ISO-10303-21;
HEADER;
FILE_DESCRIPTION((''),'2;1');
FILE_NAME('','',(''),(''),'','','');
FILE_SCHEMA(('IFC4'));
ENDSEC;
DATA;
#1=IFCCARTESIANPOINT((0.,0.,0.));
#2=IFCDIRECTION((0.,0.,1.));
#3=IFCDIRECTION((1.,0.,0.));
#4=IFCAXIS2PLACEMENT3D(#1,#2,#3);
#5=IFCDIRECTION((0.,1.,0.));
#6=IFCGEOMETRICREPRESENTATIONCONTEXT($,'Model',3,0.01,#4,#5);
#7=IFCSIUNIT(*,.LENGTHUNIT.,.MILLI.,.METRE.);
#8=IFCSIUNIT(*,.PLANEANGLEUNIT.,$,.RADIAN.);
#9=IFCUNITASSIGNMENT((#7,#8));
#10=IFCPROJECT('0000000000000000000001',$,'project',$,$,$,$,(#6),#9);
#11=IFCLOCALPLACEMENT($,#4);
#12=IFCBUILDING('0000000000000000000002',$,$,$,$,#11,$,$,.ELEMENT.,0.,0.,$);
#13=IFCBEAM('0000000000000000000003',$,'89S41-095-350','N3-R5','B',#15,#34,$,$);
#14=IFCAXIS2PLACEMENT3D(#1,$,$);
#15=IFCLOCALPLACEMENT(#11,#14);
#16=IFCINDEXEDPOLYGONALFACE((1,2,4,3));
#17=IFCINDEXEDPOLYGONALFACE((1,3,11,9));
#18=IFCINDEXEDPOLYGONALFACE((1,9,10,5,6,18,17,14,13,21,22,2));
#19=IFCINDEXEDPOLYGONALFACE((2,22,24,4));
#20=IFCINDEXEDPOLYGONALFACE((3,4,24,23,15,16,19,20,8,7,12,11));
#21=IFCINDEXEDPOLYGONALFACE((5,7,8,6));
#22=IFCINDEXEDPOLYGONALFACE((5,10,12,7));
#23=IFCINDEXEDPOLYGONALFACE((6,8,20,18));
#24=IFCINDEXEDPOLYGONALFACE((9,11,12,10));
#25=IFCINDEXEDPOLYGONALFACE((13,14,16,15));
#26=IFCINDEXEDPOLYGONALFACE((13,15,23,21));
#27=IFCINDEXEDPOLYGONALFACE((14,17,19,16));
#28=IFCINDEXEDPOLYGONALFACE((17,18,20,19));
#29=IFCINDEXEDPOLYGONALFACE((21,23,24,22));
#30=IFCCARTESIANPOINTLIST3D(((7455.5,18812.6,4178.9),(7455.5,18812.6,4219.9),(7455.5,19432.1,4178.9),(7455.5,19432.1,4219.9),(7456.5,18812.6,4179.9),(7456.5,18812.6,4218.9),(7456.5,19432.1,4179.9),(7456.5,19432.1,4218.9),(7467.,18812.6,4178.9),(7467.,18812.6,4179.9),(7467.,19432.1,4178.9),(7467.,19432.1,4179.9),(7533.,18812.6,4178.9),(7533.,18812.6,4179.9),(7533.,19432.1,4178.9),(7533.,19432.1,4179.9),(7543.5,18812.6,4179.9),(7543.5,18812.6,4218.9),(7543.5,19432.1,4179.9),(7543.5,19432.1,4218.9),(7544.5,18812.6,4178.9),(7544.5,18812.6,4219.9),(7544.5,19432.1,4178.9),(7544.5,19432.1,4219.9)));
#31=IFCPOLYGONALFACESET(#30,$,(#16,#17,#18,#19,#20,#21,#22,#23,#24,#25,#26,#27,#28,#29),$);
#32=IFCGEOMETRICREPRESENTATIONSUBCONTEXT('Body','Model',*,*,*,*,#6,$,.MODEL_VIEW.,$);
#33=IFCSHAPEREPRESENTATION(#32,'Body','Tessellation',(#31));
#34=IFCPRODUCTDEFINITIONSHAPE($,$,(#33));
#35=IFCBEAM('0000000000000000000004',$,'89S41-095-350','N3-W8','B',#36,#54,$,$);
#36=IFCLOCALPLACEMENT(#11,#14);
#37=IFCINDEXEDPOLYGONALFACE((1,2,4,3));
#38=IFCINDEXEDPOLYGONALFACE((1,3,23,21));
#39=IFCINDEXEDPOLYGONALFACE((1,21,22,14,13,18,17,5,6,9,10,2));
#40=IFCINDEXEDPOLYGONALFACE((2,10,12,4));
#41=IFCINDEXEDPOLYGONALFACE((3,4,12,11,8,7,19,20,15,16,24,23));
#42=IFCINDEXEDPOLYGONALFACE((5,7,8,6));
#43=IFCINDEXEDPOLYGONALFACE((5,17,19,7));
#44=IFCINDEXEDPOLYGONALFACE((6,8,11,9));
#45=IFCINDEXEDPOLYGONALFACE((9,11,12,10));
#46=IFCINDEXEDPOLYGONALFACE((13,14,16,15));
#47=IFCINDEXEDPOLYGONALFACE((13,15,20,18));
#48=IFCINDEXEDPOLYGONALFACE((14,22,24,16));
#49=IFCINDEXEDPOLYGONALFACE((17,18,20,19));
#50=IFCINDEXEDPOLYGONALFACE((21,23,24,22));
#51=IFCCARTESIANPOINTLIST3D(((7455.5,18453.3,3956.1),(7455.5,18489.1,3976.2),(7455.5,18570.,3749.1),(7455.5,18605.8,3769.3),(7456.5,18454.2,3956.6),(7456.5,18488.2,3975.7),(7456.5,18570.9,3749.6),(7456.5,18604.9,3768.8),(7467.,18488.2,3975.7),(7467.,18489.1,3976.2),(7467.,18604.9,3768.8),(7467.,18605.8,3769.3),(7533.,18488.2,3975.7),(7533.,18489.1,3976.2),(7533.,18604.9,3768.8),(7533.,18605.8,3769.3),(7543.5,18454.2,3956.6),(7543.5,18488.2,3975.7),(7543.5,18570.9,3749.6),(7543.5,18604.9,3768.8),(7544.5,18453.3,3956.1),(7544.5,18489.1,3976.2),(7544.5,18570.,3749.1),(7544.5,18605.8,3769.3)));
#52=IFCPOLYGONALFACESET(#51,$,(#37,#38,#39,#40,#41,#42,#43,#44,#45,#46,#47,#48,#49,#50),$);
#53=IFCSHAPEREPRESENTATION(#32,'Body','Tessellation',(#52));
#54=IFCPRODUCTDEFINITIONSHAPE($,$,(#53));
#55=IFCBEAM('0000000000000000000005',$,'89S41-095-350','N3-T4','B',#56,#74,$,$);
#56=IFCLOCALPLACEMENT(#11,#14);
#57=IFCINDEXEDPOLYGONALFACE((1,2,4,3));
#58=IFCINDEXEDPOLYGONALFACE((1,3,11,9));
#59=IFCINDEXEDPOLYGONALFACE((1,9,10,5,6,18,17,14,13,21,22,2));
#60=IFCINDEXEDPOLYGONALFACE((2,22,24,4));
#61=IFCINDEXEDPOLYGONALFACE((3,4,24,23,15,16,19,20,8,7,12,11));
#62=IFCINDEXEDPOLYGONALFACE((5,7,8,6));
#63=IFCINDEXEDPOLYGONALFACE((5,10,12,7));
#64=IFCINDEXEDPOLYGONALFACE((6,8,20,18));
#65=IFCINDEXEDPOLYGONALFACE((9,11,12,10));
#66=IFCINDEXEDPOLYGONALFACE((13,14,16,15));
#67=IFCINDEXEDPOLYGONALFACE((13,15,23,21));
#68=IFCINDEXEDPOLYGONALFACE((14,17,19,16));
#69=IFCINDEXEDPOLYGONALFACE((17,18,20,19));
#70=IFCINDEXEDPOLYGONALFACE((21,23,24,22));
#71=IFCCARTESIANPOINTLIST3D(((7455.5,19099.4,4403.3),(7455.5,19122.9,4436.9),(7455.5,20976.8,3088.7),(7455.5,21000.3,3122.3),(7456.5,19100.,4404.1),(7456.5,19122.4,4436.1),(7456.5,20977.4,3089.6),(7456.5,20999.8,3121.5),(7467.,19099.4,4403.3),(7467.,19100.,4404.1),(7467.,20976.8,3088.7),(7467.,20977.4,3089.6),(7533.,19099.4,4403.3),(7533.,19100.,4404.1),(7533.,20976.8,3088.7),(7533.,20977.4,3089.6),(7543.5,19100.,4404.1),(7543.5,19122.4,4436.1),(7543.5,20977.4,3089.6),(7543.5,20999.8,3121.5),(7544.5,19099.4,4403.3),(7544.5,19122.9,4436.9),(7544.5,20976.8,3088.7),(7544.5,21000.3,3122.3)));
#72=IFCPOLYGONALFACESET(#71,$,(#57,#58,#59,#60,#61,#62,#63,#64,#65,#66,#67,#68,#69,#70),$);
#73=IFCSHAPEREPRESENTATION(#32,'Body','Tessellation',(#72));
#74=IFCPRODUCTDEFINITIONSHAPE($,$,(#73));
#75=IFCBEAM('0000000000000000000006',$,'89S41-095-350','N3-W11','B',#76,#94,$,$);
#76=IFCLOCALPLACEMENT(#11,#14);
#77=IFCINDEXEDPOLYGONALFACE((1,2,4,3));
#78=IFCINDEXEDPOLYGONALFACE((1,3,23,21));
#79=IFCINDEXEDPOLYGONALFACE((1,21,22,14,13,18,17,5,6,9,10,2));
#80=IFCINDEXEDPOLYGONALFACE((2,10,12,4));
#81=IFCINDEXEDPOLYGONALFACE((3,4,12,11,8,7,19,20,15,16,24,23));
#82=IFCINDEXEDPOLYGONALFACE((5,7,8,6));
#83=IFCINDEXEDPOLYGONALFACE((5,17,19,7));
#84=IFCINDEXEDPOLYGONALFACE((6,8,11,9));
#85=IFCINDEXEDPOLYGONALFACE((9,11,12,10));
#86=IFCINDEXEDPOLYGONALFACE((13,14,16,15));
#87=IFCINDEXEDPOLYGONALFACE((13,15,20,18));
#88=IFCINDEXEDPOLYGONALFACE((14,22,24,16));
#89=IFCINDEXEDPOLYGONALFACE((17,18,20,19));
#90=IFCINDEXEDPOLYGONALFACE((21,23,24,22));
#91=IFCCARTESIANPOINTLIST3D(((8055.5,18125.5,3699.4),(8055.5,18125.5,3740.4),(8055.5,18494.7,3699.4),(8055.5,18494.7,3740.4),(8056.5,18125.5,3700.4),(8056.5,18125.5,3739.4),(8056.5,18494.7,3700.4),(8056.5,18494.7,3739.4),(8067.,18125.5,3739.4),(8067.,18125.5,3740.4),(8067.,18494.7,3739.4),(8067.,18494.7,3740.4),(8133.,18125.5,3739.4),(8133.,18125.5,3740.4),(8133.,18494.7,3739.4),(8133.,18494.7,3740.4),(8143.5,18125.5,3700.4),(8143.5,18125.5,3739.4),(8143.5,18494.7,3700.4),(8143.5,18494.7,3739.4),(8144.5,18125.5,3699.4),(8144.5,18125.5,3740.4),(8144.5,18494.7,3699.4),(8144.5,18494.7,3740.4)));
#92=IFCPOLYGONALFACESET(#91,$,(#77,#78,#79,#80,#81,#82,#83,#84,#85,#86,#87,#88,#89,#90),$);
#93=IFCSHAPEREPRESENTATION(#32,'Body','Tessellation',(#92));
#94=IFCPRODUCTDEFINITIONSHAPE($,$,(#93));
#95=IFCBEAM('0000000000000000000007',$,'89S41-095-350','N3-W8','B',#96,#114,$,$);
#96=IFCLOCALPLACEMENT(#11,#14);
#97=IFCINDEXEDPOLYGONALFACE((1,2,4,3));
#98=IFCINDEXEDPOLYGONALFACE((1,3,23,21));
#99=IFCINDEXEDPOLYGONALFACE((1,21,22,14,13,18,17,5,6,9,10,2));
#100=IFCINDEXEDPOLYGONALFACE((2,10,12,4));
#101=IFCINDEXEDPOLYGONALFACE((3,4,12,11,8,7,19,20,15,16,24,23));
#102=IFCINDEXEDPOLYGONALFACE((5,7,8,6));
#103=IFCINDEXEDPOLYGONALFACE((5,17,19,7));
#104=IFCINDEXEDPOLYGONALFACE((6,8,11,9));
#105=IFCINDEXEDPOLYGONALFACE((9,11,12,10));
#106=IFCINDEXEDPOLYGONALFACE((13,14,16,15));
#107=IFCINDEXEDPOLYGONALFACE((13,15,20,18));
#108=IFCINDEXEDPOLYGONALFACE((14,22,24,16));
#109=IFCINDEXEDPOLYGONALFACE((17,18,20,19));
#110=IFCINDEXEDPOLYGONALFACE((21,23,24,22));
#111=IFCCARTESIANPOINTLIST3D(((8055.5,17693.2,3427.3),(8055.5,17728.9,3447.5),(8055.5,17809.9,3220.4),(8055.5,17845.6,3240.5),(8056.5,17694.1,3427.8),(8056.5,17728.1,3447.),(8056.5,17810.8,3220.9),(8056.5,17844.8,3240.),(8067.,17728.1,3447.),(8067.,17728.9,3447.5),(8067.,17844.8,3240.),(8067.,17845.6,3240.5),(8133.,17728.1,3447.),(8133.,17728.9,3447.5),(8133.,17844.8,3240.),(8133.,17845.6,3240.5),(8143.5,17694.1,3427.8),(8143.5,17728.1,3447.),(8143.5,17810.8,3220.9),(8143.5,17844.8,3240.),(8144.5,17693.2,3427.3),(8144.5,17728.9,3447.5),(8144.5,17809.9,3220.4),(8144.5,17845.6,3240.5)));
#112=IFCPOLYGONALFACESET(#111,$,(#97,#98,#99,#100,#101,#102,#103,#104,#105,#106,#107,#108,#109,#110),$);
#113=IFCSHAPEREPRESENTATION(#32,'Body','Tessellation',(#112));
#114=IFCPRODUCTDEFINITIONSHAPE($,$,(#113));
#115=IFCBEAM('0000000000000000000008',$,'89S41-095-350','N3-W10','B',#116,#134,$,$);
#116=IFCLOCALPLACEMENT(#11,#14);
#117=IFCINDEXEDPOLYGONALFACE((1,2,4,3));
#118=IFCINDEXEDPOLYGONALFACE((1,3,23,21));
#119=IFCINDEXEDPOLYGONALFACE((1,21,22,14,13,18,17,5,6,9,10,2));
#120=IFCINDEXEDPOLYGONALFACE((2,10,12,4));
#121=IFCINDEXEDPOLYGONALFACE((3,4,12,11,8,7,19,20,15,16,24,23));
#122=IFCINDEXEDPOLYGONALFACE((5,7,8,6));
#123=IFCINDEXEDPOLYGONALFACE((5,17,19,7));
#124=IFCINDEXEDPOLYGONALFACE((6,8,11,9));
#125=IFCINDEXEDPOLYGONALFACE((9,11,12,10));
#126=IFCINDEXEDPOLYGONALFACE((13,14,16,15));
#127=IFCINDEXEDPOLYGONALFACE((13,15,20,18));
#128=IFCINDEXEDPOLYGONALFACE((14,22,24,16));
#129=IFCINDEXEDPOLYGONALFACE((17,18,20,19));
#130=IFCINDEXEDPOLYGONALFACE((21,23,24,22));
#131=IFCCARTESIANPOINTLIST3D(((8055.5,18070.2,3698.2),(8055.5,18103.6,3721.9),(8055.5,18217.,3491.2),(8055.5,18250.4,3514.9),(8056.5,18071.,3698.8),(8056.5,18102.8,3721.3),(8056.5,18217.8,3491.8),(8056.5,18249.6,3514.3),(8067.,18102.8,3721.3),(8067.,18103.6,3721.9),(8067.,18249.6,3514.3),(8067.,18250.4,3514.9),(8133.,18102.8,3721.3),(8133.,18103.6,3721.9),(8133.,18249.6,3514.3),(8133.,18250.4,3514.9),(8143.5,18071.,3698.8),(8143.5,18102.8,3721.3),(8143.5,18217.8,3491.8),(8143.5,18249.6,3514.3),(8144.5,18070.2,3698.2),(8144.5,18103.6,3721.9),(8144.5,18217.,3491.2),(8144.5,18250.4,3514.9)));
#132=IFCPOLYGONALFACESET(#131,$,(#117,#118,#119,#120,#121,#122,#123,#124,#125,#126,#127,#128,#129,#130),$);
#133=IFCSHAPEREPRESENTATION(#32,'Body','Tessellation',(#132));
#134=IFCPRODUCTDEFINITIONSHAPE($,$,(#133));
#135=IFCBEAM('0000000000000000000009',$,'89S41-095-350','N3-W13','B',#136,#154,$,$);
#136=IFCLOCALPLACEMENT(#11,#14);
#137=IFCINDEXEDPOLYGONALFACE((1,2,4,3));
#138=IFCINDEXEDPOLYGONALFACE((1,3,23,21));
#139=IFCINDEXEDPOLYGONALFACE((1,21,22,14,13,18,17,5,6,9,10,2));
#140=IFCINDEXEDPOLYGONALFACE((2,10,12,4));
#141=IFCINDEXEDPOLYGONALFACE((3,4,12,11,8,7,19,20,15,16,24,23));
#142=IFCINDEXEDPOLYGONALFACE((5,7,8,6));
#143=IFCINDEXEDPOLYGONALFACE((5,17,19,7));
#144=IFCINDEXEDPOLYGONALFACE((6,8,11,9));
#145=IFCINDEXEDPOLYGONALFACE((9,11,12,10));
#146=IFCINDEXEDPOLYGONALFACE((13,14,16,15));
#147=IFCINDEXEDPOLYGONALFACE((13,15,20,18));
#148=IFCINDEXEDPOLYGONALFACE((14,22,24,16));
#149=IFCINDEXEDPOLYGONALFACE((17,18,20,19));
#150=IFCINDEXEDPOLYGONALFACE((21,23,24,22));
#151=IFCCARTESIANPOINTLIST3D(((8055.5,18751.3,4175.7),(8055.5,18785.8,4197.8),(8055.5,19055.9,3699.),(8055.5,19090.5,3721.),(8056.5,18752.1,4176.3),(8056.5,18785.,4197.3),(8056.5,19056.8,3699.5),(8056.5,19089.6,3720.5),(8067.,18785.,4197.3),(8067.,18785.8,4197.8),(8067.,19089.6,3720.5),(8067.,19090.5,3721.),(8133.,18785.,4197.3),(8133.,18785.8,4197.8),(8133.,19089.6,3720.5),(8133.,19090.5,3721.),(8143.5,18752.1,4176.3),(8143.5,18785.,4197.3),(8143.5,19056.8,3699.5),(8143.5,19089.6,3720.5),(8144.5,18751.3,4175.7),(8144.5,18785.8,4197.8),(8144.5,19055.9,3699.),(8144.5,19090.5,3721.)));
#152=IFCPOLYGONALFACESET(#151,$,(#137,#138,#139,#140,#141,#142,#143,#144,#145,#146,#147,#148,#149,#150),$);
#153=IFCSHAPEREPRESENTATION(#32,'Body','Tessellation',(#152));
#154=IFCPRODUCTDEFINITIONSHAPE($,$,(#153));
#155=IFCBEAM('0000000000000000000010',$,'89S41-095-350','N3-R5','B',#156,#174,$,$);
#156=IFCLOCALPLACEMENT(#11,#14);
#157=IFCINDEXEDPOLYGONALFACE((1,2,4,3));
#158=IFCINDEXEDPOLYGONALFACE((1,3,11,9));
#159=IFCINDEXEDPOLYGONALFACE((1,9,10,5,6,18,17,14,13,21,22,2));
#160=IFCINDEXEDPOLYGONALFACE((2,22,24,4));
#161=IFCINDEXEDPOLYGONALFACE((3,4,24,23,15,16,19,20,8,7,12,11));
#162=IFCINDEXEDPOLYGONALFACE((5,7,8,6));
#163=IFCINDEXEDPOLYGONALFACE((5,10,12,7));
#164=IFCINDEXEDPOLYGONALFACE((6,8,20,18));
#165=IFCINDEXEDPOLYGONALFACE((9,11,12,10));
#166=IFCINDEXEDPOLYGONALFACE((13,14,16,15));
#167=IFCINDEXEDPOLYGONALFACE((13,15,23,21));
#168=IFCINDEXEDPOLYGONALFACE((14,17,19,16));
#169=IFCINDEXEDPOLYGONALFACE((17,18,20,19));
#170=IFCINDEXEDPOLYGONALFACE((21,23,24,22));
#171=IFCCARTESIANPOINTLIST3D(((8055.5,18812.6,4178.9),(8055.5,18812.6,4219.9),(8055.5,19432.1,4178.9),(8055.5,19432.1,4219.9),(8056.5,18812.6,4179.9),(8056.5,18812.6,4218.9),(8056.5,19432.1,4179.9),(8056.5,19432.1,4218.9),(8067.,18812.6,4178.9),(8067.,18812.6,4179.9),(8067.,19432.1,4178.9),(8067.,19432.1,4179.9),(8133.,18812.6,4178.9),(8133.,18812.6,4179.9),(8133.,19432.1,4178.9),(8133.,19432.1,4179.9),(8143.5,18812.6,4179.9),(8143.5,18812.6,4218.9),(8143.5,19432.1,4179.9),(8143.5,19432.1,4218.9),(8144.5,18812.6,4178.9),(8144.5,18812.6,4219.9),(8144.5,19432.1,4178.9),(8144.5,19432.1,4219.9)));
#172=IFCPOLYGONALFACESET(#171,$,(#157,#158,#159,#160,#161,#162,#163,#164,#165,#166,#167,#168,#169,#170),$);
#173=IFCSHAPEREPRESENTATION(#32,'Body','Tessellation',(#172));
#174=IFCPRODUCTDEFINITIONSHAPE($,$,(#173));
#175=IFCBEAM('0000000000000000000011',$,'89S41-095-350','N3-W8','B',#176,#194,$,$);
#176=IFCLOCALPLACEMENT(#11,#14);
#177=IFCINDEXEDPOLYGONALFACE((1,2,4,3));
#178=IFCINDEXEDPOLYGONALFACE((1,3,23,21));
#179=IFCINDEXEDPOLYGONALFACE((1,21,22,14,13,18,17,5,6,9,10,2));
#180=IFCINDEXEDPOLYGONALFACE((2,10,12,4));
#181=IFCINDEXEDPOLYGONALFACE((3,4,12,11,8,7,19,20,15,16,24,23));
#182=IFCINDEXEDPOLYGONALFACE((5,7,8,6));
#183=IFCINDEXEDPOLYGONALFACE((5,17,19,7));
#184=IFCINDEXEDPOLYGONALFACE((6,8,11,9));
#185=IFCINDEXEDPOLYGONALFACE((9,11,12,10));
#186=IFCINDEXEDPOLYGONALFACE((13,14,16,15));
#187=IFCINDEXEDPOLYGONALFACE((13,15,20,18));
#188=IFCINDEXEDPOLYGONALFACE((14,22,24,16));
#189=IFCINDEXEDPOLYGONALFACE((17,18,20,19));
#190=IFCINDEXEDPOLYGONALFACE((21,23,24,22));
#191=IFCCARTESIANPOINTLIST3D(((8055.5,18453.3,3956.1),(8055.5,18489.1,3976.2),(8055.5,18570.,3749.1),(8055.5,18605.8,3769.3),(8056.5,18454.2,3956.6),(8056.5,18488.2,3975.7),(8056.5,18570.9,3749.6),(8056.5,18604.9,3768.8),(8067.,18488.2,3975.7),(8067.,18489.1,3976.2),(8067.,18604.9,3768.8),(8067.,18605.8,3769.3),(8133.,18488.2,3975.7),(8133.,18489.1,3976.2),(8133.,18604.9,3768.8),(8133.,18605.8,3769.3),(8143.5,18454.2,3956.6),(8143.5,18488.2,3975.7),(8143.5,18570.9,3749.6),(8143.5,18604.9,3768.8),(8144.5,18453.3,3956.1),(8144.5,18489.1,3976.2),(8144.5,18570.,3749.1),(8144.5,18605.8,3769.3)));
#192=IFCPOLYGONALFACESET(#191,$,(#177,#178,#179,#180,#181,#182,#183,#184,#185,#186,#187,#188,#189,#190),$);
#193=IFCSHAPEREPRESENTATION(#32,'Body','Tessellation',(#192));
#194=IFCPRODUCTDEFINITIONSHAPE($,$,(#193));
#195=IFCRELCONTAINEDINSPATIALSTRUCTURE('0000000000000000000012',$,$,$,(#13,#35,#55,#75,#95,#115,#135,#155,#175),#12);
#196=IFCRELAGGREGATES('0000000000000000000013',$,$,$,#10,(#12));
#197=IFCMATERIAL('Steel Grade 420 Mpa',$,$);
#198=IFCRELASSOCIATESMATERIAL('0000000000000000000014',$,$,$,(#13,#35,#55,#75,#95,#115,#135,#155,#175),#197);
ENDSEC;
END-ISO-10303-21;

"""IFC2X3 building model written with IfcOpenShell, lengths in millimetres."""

from ifc_helpers import new_model, si_unit, direction, frame, origin, origin_with_axes, origin_2d_with_axis, place, context, subcontext, project, spatial, c_section, extrude, source, transform, mapped, material, element, save


model = new_model("IFC2X3")

# Units and contexts
model_context = context("Model", 3, precision=0.01, world=origin_with_axes(), true_north=direction((0.0, 1.0, 0.0)))
body_context = subcontext(model_context, "Body", "Model", "MODEL_VIEW")
ifc_project = project(units=[si_unit("LENGTHUNIT", "METRE", prefix="MILLI"), si_unit("PLANEANGLEUNIT", "RADIAN")], contexts=[model_context])

# Building
building_placement = place(None, origin_with_axes())
building = spatial("IfcBuilding", under=ifc_project, at=building_placement, CompositionType="ELEMENT", ElevationOfRefHeight=0.0, ElevationOfTerrain=0.0)

# Shared definitions
ifc_material = material(Name="Steel Grade 420 Mpa")

# Beams
shared_shape_1 = source(origin(), body_context, "Body", "SweptSolid", [
    extrude(c_section(Depth=89.0, Width=41.0, WallThickness=1.0, Girth=11.5, at=origin_2d_with_axis()), origin_with_axes(), (0.0, 0.0, 1.0), 619.5),
])
beam_1_placement = place(None, frame((7500.0, 18812.6, 4199.4), z_axis=(0.0, 1.0, 0.0), x_axis=(0.0, 0.0, -1.0)))
element("IfcBeam", 1, at=beam_1_placement, inside=building, material=ifc_material, Name="89S41-095-350", Description="N3-R5", ObjectType="B", context=body_context, shape_type="MappedRepresentation", body=[
    mapped(shared_shape_1, transform((0.0, 0.0, 0.0), scale=1.0)),
])
shared_shape_2 = source(origin(), body_context, "Body", "SweptSolid", [
    extrude(c_section(Depth=89.0, Width=41.0, WallThickness=1.0, Girth=11.5, at=origin_2d_with_axis()), origin_with_axes(), (0.0, 0.0, 1.0), 237.6),
])
beam_2_placement = place(None, frame((7500.0, 18587.9, 3759.2), z_axis=(0.0, -0.491169, 0.871064), x_axis=(0.0, 0.871064, 0.491169)))
element("IfcBeam", 2, at=beam_2_placement, inside=building, material=ifc_material, Name="89S41-095-350", Description="N3-W8", ObjectType="B", context=body_context, shape_type="MappedRepresentation", body=[
    mapped(shared_shape_2, transform((0.0, 0.0, 0.0), scale=1.0)),
])
shared_shape_3 = source(origin(), body_context, "Body", "SweptSolid", [
    extrude(c_section(Depth=89.0, Width=41.0, WallThickness=1.0, Girth=11.5, at=origin_2d_with_axis()), origin_with_axes(), (0.0, 0.0, 1.0), 2291.9),
])
beam_3_placement = place(None, frame((7500.0, 19111.2, 4420.1), z_axis=(0.0, 0.819152, -0.573576), x_axis=(0.0, -0.573576, -0.819152)))
element("IfcBeam", 3, at=beam_3_placement, inside=building, material=ifc_material, Name="89S41-095-350", Description="N3-T4", ObjectType="B", context=body_context, shape_type="MappedRepresentation", body=[
    mapped(shared_shape_3, transform((0.0, 0.0, 0.0), scale=1.0)),
])
shared_shape_4 = source(origin(), body_context, "Body", "SweptSolid", [
    extrude(c_section(Depth=89.0, Width=41.0, WallThickness=1.0, Girth=11.5, at=origin_2d_with_axis()), origin_with_axes(), (0.0, 0.0, 1.0), 369.2),
])
beam_4_placement = place(None, frame((8100.0, 18494.7, 3719.9), z_axis=(0.0, -1.0, 0.0), x_axis=(0.0, 0.0, 1.0)))
element("IfcBeam", 4, at=beam_4_placement, inside=building, material=ifc_material, Name="89S41-095-350", Description="N3-W11", ObjectType="B", context=body_context, shape_type="MappedRepresentation", body=[
    mapped(shared_shape_4, transform((0.0, 0.0, 0.0), scale=1.0)),
])
shared_shape_5 = source(origin(), body_context, "Body", "SweptSolid", [
    extrude(c_section(Depth=89.0, Width=41.0, WallThickness=1.0, Girth=11.5, at=origin_2d_with_axis()), origin_with_axes(), (0.0, 0.0, 1.0), 237.6),
])
beam_5_placement = place(None, frame((8100.0, 17827.8, 3230.5), z_axis=(0.0, -0.491169, 0.871064), x_axis=(0.0, 0.871064, 0.491169)))
element("IfcBeam", 5, at=beam_5_placement, inside=building, material=ifc_material, Name="89S41-095-350", Description="N3-W8", ObjectType="B", context=body_context, shape_type="MappedRepresentation", body=[
    mapped(shared_shape_5, transform((0.0, 0.0, 0.0), scale=1.0)),
])
shared_shape_6 = source(origin(), body_context, "Body", "SweptSolid", [
    extrude(c_section(Depth=89.0, Width=41.0, WallThickness=1.0, Girth=11.5, at=origin_2d_with_axis()), origin_with_axes(), (0.0, 0.0, 1.0), 253.8),
])
beam_6_placement = place(None, frame((8100.0, 18233.7, 3503.0), z_axis=(0.0, -0.578484, 0.815694), x_axis=(0.0, 0.815694, 0.578484)))
element("IfcBeam", 6, at=beam_6_placement, inside=building, material=ifc_material, Name="89S41-095-350", Description="N3-W10", ObjectType="B", context=body_context, shape_type="MappedRepresentation", body=[
    mapped(shared_shape_6, transform((0.0, 0.0, 0.0), scale=1.0)),
])
shared_shape_7 = source(origin(), body_context, "Body", "SweptSolid", [
    extrude(c_section(Depth=89.0, Width=41.0, WallThickness=1.0, Girth=11.5, at=origin_2d_with_axis()), origin_with_axes(), (0.0, 0.0, 1.0), 565.8),
])
beam_7_placement = place(None, frame((8100.0, 19073.2, 3710.0), z_axis=(0.0, -0.538498, 0.842627), x_axis=(0.0, 0.842627, 0.538498)))
element("IfcBeam", 7, at=beam_7_placement, inside=building, material=ifc_material, Name="89S41-095-350", Description="N3-W13", ObjectType="B", context=body_context, shape_type="MappedRepresentation", body=[
    mapped(shared_shape_7, transform((0.0, 0.0, 0.0), scale=1.0)),
])
shared_shape_8 = source(origin(), body_context, "Body", "SweptSolid", [
    extrude(c_section(Depth=89.0, Width=41.0, WallThickness=1.0, Girth=11.5, at=origin_2d_with_axis()), origin_with_axes(), (0.0, 0.0, 1.0), 619.5),
])
beam_8_placement = place(None, frame((8100.0, 18812.6, 4199.4), z_axis=(0.0, 1.0, 0.0), x_axis=(0.0, 0.0, -1.0)))
element("IfcBeam", 8, at=beam_8_placement, inside=building, material=ifc_material, Name="89S41-095-350", Description="N3-R5", ObjectType="B", context=body_context, shape_type="MappedRepresentation", body=[
    mapped(shared_shape_8, transform((0.0, 0.0, 0.0), scale=1.0)),
])
shared_shape_9 = source(origin(), body_context, "Body", "SweptSolid", [
    extrude(c_section(Depth=89.0, Width=41.0, WallThickness=1.0, Girth=11.5, at=origin_2d_with_axis()), origin_with_axes(), (0.0, 0.0, 1.0), 237.6),
])
beam_9_placement = place(None, frame((8100.0, 18587.9, 3759.2), z_axis=(0.0, -0.491169, 0.871064), x_axis=(0.0, 0.871064, 0.491169)))
element("IfcBeam", 9, at=beam_9_placement, inside=building, material=ifc_material, Name="89S41-095-350", Description="N3-W8", ObjectType="B", context=body_context, shape_type="MappedRepresentation", body=[
    mapped(shared_shape_9, transform((0.0, 0.0, 0.0), scale=1.0)),
])

save(model, "model.ifc")
